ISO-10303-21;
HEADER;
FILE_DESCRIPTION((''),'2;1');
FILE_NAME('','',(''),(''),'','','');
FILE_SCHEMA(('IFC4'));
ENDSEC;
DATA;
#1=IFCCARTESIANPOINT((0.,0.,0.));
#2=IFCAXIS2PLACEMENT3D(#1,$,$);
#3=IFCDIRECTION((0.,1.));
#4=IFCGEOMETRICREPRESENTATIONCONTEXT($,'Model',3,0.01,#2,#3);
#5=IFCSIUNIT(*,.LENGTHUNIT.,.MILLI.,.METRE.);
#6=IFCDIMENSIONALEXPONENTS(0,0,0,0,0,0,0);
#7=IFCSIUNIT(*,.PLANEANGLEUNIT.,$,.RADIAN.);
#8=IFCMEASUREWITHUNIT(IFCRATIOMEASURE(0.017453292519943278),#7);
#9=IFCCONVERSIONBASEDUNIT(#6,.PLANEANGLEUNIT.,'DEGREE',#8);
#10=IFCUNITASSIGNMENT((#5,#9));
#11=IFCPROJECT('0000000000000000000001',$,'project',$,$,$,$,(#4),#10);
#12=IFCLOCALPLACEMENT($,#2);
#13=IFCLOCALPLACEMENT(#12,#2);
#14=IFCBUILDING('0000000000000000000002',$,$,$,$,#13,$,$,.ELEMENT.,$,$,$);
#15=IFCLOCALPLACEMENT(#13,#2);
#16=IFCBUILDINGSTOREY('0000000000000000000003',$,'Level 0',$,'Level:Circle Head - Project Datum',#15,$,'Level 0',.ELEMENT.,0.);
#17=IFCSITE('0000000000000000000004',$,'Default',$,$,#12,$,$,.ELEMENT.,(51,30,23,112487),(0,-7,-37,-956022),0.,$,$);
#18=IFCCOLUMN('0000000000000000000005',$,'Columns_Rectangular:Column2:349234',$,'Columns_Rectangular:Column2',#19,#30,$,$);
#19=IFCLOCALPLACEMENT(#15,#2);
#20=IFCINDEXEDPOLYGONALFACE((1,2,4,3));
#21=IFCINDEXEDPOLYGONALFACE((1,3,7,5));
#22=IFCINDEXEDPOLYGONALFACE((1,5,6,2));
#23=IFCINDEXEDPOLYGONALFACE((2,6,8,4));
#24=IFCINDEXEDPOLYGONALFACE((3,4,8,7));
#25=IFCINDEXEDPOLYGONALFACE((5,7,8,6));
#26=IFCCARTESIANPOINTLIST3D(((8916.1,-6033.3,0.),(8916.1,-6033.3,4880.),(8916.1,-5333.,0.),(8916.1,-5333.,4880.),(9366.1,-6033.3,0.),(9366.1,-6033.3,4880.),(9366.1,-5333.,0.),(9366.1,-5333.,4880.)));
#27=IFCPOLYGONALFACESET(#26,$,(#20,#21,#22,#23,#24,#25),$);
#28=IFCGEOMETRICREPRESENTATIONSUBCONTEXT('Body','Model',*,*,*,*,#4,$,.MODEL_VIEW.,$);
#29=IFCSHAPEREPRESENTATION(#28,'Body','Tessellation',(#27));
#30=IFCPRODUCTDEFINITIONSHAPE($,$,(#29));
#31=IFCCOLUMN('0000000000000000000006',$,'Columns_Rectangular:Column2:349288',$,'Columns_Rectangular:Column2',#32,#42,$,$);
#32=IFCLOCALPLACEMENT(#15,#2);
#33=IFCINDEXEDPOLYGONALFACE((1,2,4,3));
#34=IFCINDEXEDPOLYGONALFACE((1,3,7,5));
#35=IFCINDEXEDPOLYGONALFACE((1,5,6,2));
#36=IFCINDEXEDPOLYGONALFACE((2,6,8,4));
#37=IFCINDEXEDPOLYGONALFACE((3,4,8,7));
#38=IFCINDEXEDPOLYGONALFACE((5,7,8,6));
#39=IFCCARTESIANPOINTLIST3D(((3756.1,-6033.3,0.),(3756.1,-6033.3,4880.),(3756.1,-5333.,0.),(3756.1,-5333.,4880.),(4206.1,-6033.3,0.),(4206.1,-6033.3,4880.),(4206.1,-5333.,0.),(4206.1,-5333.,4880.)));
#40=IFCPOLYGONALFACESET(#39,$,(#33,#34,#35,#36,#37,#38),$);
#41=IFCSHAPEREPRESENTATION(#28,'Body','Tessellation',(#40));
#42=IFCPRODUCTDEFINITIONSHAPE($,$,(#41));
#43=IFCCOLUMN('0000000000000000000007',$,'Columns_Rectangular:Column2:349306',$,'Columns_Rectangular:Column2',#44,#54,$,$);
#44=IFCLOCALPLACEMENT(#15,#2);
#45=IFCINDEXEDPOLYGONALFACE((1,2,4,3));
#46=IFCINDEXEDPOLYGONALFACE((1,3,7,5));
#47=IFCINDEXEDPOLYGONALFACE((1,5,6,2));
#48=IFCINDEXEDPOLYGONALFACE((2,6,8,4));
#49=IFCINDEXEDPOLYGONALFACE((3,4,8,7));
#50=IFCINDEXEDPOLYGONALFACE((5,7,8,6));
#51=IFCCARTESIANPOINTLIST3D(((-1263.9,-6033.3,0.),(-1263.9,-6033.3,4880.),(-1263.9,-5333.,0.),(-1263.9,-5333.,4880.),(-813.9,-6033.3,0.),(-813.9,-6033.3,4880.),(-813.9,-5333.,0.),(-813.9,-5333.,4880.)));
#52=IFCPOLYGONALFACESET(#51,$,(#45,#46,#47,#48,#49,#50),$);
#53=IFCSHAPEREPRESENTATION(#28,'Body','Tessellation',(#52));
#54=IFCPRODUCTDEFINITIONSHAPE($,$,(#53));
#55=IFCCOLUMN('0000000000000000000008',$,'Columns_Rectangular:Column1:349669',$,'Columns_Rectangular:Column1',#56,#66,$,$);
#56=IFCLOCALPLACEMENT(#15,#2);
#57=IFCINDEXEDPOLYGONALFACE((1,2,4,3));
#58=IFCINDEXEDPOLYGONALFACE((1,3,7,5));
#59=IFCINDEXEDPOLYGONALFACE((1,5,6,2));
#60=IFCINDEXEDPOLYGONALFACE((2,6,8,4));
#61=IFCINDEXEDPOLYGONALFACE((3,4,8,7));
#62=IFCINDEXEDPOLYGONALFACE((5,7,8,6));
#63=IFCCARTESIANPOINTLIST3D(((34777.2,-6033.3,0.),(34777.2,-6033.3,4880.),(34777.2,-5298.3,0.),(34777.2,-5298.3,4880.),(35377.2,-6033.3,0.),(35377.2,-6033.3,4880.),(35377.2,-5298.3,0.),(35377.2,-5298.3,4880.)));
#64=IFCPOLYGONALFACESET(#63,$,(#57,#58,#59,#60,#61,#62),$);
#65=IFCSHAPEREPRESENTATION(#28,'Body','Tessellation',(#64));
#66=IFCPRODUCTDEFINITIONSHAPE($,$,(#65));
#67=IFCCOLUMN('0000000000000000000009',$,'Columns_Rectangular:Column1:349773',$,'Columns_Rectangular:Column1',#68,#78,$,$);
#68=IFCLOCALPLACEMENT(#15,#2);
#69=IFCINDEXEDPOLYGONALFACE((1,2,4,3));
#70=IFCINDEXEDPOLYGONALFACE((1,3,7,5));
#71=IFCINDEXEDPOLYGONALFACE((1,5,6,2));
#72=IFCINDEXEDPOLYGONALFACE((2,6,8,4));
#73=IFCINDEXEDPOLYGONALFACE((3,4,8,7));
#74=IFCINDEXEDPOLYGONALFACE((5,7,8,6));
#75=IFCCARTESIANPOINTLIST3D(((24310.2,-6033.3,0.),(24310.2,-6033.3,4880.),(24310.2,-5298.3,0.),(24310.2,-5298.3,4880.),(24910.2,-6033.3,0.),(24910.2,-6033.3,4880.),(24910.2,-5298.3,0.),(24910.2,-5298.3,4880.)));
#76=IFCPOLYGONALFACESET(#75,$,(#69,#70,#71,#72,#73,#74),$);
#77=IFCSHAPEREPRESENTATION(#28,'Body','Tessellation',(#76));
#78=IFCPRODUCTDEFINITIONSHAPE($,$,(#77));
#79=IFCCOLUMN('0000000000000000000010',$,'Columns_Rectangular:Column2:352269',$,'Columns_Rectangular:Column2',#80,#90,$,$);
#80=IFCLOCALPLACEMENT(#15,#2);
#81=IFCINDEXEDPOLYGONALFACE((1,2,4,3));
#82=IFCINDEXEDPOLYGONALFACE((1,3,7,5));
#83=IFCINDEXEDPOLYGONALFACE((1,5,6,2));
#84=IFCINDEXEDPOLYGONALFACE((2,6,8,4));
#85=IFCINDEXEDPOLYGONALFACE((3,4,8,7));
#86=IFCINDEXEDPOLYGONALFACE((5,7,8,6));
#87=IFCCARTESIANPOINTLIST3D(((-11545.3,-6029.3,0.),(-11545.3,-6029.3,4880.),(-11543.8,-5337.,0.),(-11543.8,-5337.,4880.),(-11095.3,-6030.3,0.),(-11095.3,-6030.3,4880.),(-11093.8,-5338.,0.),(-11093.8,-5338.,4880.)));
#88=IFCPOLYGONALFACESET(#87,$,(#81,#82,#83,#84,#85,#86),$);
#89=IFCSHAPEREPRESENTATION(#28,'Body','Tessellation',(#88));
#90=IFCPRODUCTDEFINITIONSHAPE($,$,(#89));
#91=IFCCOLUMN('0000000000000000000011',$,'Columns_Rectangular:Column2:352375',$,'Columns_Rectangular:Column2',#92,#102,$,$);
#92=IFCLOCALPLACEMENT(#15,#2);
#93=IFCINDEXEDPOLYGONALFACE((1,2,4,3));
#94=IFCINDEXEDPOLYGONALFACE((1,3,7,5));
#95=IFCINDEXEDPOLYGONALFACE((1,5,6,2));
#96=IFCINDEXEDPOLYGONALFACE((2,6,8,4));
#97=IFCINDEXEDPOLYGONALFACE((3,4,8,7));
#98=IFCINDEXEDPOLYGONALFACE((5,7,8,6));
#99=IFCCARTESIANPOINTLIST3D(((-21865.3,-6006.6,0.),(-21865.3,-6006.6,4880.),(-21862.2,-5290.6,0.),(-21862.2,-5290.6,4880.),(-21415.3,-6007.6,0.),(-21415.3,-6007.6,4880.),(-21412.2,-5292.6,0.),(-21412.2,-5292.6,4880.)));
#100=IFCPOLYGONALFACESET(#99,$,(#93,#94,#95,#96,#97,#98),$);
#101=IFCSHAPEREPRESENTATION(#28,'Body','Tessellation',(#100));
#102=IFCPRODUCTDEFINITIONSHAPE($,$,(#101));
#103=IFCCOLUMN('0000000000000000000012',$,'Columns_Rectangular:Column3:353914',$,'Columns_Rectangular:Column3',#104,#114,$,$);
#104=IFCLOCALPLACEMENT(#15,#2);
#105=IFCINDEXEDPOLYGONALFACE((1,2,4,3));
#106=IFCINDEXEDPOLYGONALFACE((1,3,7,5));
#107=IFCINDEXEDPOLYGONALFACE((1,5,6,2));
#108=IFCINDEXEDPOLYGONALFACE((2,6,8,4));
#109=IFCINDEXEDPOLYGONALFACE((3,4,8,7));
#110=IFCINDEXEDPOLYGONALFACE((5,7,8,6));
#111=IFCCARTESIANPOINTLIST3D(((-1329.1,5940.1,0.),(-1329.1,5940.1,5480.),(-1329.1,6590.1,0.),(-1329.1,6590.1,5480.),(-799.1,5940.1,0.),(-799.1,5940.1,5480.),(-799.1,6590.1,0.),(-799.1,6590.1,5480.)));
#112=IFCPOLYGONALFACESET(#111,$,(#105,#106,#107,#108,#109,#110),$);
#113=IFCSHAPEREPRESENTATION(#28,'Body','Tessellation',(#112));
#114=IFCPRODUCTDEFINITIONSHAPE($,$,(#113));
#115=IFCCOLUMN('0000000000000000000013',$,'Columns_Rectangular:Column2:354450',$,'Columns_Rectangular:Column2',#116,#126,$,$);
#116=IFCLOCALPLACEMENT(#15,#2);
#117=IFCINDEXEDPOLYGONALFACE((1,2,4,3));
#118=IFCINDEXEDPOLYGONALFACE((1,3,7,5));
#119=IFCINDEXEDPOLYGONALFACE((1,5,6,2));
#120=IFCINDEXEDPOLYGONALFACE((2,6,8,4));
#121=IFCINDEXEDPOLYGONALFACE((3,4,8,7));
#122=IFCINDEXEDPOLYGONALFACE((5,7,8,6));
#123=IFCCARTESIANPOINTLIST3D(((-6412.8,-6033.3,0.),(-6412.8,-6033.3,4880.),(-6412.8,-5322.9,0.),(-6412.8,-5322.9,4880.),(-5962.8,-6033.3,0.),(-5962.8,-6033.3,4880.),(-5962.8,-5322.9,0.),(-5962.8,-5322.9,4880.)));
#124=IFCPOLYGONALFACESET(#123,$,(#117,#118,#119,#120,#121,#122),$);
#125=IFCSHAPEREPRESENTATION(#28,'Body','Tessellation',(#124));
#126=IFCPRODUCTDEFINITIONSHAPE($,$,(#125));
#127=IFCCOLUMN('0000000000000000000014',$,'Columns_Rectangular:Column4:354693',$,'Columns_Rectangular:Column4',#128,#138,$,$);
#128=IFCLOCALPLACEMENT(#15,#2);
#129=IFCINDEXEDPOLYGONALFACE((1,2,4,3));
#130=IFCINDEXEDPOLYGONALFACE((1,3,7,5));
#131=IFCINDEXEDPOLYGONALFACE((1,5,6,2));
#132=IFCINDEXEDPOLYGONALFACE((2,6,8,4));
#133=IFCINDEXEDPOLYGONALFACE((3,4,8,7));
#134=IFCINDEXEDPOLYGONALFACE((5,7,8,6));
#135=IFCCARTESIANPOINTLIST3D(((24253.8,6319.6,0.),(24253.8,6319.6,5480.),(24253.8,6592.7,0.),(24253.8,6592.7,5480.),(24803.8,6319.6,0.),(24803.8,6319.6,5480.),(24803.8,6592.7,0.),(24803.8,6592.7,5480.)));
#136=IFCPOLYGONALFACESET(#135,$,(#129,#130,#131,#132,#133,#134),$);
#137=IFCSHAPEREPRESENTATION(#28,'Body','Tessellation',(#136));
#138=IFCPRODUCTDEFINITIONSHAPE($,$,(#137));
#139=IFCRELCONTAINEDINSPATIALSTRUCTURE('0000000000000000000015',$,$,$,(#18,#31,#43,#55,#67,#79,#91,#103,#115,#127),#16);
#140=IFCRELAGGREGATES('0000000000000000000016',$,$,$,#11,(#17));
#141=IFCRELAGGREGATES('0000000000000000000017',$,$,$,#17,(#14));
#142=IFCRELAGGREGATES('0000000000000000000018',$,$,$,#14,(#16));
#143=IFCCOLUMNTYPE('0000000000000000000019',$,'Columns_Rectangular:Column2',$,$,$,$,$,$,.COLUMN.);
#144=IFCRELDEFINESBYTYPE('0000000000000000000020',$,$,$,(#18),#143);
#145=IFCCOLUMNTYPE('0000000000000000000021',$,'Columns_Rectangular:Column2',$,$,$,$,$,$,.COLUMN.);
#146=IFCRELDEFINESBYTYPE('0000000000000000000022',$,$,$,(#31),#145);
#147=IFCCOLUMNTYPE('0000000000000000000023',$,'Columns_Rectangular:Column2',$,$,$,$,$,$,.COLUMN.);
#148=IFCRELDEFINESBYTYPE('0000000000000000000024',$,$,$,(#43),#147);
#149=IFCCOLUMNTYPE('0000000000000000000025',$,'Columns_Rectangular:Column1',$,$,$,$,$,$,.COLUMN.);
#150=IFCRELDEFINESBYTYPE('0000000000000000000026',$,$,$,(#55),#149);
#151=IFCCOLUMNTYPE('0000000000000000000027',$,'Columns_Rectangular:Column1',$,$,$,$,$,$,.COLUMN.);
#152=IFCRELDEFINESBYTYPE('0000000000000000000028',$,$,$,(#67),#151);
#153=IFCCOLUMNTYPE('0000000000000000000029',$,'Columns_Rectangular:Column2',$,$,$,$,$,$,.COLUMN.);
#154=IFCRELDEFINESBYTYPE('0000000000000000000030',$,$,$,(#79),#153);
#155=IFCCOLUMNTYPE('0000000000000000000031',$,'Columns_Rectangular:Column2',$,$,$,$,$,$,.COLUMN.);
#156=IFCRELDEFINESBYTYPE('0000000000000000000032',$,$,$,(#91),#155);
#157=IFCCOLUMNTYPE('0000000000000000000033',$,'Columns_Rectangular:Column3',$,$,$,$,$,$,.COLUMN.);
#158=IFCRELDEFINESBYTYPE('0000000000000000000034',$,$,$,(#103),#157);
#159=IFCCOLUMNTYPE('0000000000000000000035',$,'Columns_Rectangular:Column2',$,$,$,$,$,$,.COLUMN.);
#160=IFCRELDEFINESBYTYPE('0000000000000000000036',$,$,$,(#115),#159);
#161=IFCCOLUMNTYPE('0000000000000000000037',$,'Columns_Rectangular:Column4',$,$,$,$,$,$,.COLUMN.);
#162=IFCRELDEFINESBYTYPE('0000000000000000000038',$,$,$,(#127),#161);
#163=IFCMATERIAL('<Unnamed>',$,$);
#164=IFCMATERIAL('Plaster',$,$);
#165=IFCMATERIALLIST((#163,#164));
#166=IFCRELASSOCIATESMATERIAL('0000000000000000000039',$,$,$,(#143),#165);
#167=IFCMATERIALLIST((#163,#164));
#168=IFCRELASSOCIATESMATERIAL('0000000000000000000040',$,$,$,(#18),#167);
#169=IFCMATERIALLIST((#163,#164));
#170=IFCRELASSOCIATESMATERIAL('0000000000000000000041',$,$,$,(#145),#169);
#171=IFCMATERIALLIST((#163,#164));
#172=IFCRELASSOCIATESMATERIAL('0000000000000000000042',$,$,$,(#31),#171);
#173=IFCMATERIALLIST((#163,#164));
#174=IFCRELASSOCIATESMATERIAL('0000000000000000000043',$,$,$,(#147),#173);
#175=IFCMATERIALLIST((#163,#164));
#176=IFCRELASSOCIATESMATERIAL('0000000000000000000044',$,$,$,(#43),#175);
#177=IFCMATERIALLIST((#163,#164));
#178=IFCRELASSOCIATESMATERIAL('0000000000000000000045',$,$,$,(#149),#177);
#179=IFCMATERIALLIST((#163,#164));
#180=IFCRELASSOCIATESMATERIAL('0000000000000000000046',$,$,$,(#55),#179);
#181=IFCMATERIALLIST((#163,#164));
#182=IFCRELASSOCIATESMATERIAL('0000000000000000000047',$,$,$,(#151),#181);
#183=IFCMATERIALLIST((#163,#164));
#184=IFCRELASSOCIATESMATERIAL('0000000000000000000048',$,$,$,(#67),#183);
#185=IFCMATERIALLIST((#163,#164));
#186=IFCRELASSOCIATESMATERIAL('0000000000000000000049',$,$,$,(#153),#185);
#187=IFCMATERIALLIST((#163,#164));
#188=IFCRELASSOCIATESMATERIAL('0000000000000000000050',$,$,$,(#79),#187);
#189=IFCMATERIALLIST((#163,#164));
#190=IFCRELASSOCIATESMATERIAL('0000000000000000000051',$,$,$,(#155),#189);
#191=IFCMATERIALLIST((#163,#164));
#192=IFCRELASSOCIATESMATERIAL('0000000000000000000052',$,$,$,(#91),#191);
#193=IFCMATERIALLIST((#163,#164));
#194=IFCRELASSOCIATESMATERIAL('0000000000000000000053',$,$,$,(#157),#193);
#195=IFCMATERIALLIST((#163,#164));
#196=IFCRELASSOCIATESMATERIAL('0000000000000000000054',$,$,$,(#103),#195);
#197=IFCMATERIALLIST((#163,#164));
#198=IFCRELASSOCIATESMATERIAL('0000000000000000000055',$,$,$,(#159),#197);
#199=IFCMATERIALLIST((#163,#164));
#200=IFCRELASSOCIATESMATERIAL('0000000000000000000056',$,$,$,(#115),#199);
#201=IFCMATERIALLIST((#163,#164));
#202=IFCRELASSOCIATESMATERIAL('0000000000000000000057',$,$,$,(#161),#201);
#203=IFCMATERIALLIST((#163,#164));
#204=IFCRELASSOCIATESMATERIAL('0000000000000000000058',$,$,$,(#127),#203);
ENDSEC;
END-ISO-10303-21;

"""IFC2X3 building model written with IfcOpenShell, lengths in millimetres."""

from ifc_helpers import new_model, entity, si_unit, converted_unit, direction, frame, frame_2d, origin, origin_2d_with_axis, place, context, subcontext, project, spatial, polyline, rectangle, outline, extrude, source, transform, mapped, material, material_list, type_object, type_shapes, element, save


model = new_model("IFC2X3")

# Units and contexts
model_context = context("Model", 3, precision=0.01, world=origin(), true_north=direction((0.0, 1.0)))
body_context = subcontext(model_context, "Body", "Model", "MODEL_VIEW")
ifc_project = project(units=[si_unit("LENGTHUNIT", "METRE", prefix="MILLI"), converted_unit("PLANEANGLEUNIT", "DEGREE", entity("IfcRatioMeasure", 0.017453292519943278), si_unit("PLANEANGLEUNIT", "RADIAN"), dimensions=[0, 0, 0, 0, 0, 0, 0])], contexts=[model_context])

# Site, building, storey
site_placement = place(None, origin())
site = spatial("IfcSite", under=ifc_project, at=site_placement, Name="Default", CompositionType="ELEMENT", RefLatitude=(51, 30, 23, 112487), RefLongitude=(0, -7, -37, -956022), RefElevation=0.0)
building_placement = place(site_placement, origin())
building = spatial("IfcBuilding", under=site, at=building_placement, CompositionType="ELEMENT")
storey_placement = place(building_placement, origin())
storey = spatial("IfcBuildingStorey", under=building, at=storey_placement, Name="Level 0", ObjectType="Level:Circle Head - Project Datum", LongName="Level 0", CompositionType="ELEMENT", Elevation=0.0)

# Columns
ifc_material_1 = material(Name="<Unnamed>")
ifc_material_2 = material(Name="Plaster")
ifc_material_list_1 = material_list([ifc_material_1, ifc_material_2])
ifc_material_list_2 = material_list([ifc_material_1, ifc_material_2])
column_type_1 = type_object("IfcColumnType", Name="Columns_Rectangular:Column2", PredefinedType="COLUMN", material=ifc_material_list_2)
shared_shape_1 = source(origin(), body_context, "Body", "SweptSolid", [
    extrude(rectangle(XDim=700.3, YDim=450.0, at=frame_2d((0.0, 0.0), x_axis=(1.0, 0.0))), frame((9141.1, -5683.1, 0.0), z_axis=(0.0, 0.0, 1.0), x_axis=(0.0, -1.0, 0.0)), (0.0, 0.0, 1.0), 4880.0),
])
type_shapes(column_type_1, [shared_shape_1])
column_1_placement = place(storey_placement, origin())
element("IfcColumn", 1, at=column_1_placement, inside=storey, type_object=column_type_1, material=ifc_material_list_1, Name="Columns_Rectangular:Column2:349234", ObjectType="Columns_Rectangular:Column2", context=body_context, shape_type="MappedRepresentation", body=[
    mapped(shared_shape_1, transform((0.0, 0.0, 0.0), scale=1.0)),
])
ifc_material_list_3 = material_list([ifc_material_1, ifc_material_2])
ifc_material_list_4 = material_list([ifc_material_1, ifc_material_2])
column_type_2 = type_object("IfcColumnType", Name="Columns_Rectangular:Column2", PredefinedType="COLUMN", material=ifc_material_list_4)
shared_shape_2 = source(origin(), body_context, "Body", "SweptSolid", [
    extrude(rectangle(XDim=700.3, YDim=450.0, at=frame_2d((0.0, 0.0), x_axis=(1.0, 0.0))), frame((3981.1, -5683.1, 0.0), z_axis=(0.0, 0.0, 1.0), x_axis=(0.0, -1.0, 0.0)), (0.0, 0.0, 1.0), 4880.0),
])
type_shapes(column_type_2, [shared_shape_2])
column_2_placement = place(storey_placement, origin())
element("IfcColumn", 2, at=column_2_placement, inside=storey, type_object=column_type_2, material=ifc_material_list_3, Name="Columns_Rectangular:Column2:349288", ObjectType="Columns_Rectangular:Column2", context=body_context, shape_type="MappedRepresentation", body=[
    mapped(shared_shape_2, transform((0.0, 0.0, 0.0), scale=1.0)),
])
ifc_material_list_5 = material_list([ifc_material_1, ifc_material_2])
ifc_material_list_6 = material_list([ifc_material_1, ifc_material_2])
column_type_3 = type_object("IfcColumnType", Name="Columns_Rectangular:Column2", PredefinedType="COLUMN", material=ifc_material_list_6)
shared_shape_3 = source(origin(), body_context, "Body", "SweptSolid", [
    extrude(rectangle(XDim=700.3, YDim=450.0, at=frame_2d((0.0, 0.0), x_axis=(1.0, 0.0))), frame((-1038.9, -5683.1, 0.0), z_axis=(0.0, 0.0, 1.0), x_axis=(0.0, -1.0, 0.0)), (0.0, 0.0, 1.0), 4880.0),
])
type_shapes(column_type_3, [shared_shape_3])
column_3_placement = place(storey_placement, origin())
element("IfcColumn", 3, at=column_3_placement, inside=storey, type_object=column_type_3, material=ifc_material_list_5, Name="Columns_Rectangular:Column2:349306", ObjectType="Columns_Rectangular:Column2", context=body_context, shape_type="MappedRepresentation", body=[
    mapped(shared_shape_3, transform((0.0, 0.0, 0.0), scale=1.0)),
])
ifc_material_list_7 = material_list([ifc_material_1, ifc_material_2])
ifc_material_list_8 = material_list([ifc_material_1, ifc_material_2])
column_type_4 = type_object("IfcColumnType", Name="Columns_Rectangular:Column1", PredefinedType="COLUMN", material=ifc_material_list_8)
shared_shape_4 = source(origin(), body_context, "Body", "SweptSolid", [
    extrude(rectangle(XDim=735.0, YDim=600.0, at=frame_2d((0.0, 0.0), x_axis=(1.0, 0.0))), frame((35077.2, -5665.8, 0.0), z_axis=(0.0, 0.0, 1.0), x_axis=(0.0, -1.0, 0.0)), (0.0, 0.0, 1.0), 4880.0),
])
type_shapes(column_type_4, [shared_shape_4])
column_4_placement = place(storey_placement, origin())
element("IfcColumn", 4, at=column_4_placement, inside=storey, type_object=column_type_4, material=ifc_material_list_7, Name="Columns_Rectangular:Column1:349669", ObjectType="Columns_Rectangular:Column1", context=body_context, shape_type="MappedRepresentation", body=[
    mapped(shared_shape_4, transform((0.0, 0.0, 0.0), scale=1.0)),
])
ifc_material_list_9 = material_list([ifc_material_1, ifc_material_2])
ifc_material_list_10 = material_list([ifc_material_1, ifc_material_2])
column_type_5 = type_object("IfcColumnType", Name="Columns_Rectangular:Column1", PredefinedType="COLUMN", material=ifc_material_list_10)
shared_shape_5 = source(origin(), body_context, "Body", "SweptSolid", [
    extrude(rectangle(XDim=735.0, YDim=600.0, at=origin_2d_with_axis()), frame((24610.2, -5665.8, 0.0), z_axis=(0.0, 0.0, 1.0), x_axis=(0.0, -1.0, 0.0)), (0.0, 0.0, 1.0), 4880.0),
])
type_shapes(column_type_5, [shared_shape_5])
column_5_placement = place(storey_placement, origin())
element("IfcColumn", 5, at=column_5_placement, inside=storey, type_object=column_type_5, material=ifc_material_list_9, Name="Columns_Rectangular:Column1:349773", ObjectType="Columns_Rectangular:Column1", context=body_context, shape_type="MappedRepresentation", body=[
    mapped(shared_shape_5, transform((0.0, 0.0, 0.0), scale=1.0)),
])
ifc_material_list_11 = material_list([ifc_material_1, ifc_material_2])
ifc_material_list_12 = material_list([ifc_material_1, ifc_material_2])
column_type_6 = type_object("IfcColumnType", Name="Columns_Rectangular:Column2", PredefinedType="COLUMN", material=ifc_material_list_12)
shared_shape_6 = source(origin(), body_context, "Body", "SweptSolid", [
    extrude(outline(polyline([(-225.0, -346.1), (225.0, -346.1), (225.0, 346.1), (-225.0, 346.1), (-225.0, -346.1)])), frame((-11319.5, -5683.6, 0.0), z_axis=(0.0, 0.0, 1.0), x_axis=(-0.999998, 0.002173, 0.0)), (0.0, 0.0, 1.0), 4880.0),
])
type_shapes(column_type_6, [shared_shape_6])
column_6_placement = place(storey_placement, origin())
element("IfcColumn", 6, at=column_6_placement, inside=storey, type_object=column_type_6, material=ifc_material_list_11, Name="Columns_Rectangular:Column2:352269", ObjectType="Columns_Rectangular:Column2", context=body_context, shape_type="MappedRepresentation", body=[
    mapped(shared_shape_6, transform((0.0, 0.0, 0.0), scale=1.0)),
])
ifc_material_list_13 = material_list([ifc_material_1, ifc_material_2])
ifc_material_list_14 = material_list([ifc_material_1, ifc_material_2])
column_type_7 = type_object("IfcColumnType", Name="Columns_Rectangular:Column2", PredefinedType="COLUMN", material=ifc_material_list_14)
shared_shape_7 = source(origin(), body_context, "Body", "SweptSolid", [
    extrude(outline(polyline([(-225.0, -357.8), (225.0, -357.8), (225.0, 358.3), (-225.0, 357.3), (-225.0, -357.8)])), frame((-21638.7, -5649.3, 0.0), z_axis=(0.0, 0.0, 1.0), x_axis=(-0.99999, 0.004372, 0.0)), (0.0, 0.0, 1.0), 4880.0),
])
type_shapes(column_type_7, [shared_shape_7])
column_7_placement = place(storey_placement, origin())
element("IfcColumn", 7, at=column_7_placement, inside=storey, type_object=column_type_7, material=ifc_material_list_13, Name="Columns_Rectangular:Column2:352375", ObjectType="Columns_Rectangular:Column2", context=body_context, shape_type="MappedRepresentation", body=[
    mapped(shared_shape_7, transform((0.0, 0.0, 0.0), scale=1.0)),
])
ifc_material_list_15 = material_list([ifc_material_1, ifc_material_2])
ifc_material_list_16 = material_list([ifc_material_1, ifc_material_2])
column_type_8 = type_object("IfcColumnType", Name="Columns_Rectangular:Column3", PredefinedType="COLUMN", material=ifc_material_list_16)
shared_shape_8 = source(origin(), body_context, "Body", "SweptSolid", [
    extrude(rectangle(XDim=650.0, YDim=530.0, at=frame_2d((0.0, 0.0), x_axis=(1.0, 0.0))), frame((-1064.1, 6265.1, 0.0), z_axis=(0.0, 0.0, 1.0), x_axis=(0.0, -1.0, 0.0)), (0.0, 0.0, 1.0), 5480.0),
])
type_shapes(column_type_8, [shared_shape_8])
column_8_placement = place(storey_placement, origin())
element("IfcColumn", 8, at=column_8_placement, inside=storey, type_object=column_type_8, material=ifc_material_list_15, Name="Columns_Rectangular:Column3:353914", ObjectType="Columns_Rectangular:Column3", context=body_context, shape_type="MappedRepresentation", body=[
    mapped(shared_shape_8, transform((0.0, 0.0, 0.0), scale=1.0)),
])
ifc_material_list_17 = material_list([ifc_material_1, ifc_material_2])
ifc_material_list_18 = material_list([ifc_material_1, ifc_material_2])
column_type_9 = type_object("IfcColumnType", Name="Columns_Rectangular:Column2", PredefinedType="COLUMN", material=ifc_material_list_18)
shared_shape_9 = source(origin(), body_context, "Body", "SweptSolid", [
    extrude(rectangle(XDim=710.3, YDim=450.0, at=frame_2d((0.0, 0.0), x_axis=(1.0, 0.0))), frame((-6187.8, -5678.1, 0.0), z_axis=(0.0, 0.0, 1.0), x_axis=(0.0, -1.0, 0.0)), (0.0, 0.0, 1.0), 4880.0),
])
type_shapes(column_type_9, [shared_shape_9])
column_9_placement = place(storey_placement, origin())
element("IfcColumn", 9, at=column_9_placement, inside=storey, type_object=column_type_9, material=ifc_material_list_17, Name="Columns_Rectangular:Column2:354450", ObjectType="Columns_Rectangular:Column2", context=body_context, shape_type="MappedRepresentation", body=[
    mapped(shared_shape_9, transform((0.0, 0.0, 0.0), scale=1.0)),
])
ifc_material_list_19 = material_list([ifc_material_1, ifc_material_2])
ifc_material_list_20 = material_list([ifc_material_1, ifc_material_2])
column_type_10 = type_object("IfcColumnType", Name="Columns_Rectangular:Column4", PredefinedType="COLUMN", material=ifc_material_list_20)
shared_shape_10 = source(origin(), body_context, "Body", "SweptSolid", [
    extrude(rectangle(XDim=273.1, YDim=550.0, at=frame_2d((0.0, 0.0), x_axis=(1.0, 0.0))), frame((24528.8, 6456.2, 0.0), z_axis=(0.0, 0.0, 1.0), x_axis=(0.0, -1.0, 0.0)), (0.0, 0.0, 1.0), 5480.0),
])
type_shapes(column_type_10, [shared_shape_10])
column_10_placement = place(storey_placement, origin())
element("IfcColumn", 10, at=column_10_placement, inside=storey, type_object=column_type_10, material=ifc_material_list_19, Name="Columns_Rectangular:Column4:354693", ObjectType="Columns_Rectangular:Column4", context=body_context, shape_type="MappedRepresentation", body=[
    mapped(shared_shape_10, transform((0.0, 0.0, 0.0), scale=1.0)),
])

save(model, "model.ifc")
